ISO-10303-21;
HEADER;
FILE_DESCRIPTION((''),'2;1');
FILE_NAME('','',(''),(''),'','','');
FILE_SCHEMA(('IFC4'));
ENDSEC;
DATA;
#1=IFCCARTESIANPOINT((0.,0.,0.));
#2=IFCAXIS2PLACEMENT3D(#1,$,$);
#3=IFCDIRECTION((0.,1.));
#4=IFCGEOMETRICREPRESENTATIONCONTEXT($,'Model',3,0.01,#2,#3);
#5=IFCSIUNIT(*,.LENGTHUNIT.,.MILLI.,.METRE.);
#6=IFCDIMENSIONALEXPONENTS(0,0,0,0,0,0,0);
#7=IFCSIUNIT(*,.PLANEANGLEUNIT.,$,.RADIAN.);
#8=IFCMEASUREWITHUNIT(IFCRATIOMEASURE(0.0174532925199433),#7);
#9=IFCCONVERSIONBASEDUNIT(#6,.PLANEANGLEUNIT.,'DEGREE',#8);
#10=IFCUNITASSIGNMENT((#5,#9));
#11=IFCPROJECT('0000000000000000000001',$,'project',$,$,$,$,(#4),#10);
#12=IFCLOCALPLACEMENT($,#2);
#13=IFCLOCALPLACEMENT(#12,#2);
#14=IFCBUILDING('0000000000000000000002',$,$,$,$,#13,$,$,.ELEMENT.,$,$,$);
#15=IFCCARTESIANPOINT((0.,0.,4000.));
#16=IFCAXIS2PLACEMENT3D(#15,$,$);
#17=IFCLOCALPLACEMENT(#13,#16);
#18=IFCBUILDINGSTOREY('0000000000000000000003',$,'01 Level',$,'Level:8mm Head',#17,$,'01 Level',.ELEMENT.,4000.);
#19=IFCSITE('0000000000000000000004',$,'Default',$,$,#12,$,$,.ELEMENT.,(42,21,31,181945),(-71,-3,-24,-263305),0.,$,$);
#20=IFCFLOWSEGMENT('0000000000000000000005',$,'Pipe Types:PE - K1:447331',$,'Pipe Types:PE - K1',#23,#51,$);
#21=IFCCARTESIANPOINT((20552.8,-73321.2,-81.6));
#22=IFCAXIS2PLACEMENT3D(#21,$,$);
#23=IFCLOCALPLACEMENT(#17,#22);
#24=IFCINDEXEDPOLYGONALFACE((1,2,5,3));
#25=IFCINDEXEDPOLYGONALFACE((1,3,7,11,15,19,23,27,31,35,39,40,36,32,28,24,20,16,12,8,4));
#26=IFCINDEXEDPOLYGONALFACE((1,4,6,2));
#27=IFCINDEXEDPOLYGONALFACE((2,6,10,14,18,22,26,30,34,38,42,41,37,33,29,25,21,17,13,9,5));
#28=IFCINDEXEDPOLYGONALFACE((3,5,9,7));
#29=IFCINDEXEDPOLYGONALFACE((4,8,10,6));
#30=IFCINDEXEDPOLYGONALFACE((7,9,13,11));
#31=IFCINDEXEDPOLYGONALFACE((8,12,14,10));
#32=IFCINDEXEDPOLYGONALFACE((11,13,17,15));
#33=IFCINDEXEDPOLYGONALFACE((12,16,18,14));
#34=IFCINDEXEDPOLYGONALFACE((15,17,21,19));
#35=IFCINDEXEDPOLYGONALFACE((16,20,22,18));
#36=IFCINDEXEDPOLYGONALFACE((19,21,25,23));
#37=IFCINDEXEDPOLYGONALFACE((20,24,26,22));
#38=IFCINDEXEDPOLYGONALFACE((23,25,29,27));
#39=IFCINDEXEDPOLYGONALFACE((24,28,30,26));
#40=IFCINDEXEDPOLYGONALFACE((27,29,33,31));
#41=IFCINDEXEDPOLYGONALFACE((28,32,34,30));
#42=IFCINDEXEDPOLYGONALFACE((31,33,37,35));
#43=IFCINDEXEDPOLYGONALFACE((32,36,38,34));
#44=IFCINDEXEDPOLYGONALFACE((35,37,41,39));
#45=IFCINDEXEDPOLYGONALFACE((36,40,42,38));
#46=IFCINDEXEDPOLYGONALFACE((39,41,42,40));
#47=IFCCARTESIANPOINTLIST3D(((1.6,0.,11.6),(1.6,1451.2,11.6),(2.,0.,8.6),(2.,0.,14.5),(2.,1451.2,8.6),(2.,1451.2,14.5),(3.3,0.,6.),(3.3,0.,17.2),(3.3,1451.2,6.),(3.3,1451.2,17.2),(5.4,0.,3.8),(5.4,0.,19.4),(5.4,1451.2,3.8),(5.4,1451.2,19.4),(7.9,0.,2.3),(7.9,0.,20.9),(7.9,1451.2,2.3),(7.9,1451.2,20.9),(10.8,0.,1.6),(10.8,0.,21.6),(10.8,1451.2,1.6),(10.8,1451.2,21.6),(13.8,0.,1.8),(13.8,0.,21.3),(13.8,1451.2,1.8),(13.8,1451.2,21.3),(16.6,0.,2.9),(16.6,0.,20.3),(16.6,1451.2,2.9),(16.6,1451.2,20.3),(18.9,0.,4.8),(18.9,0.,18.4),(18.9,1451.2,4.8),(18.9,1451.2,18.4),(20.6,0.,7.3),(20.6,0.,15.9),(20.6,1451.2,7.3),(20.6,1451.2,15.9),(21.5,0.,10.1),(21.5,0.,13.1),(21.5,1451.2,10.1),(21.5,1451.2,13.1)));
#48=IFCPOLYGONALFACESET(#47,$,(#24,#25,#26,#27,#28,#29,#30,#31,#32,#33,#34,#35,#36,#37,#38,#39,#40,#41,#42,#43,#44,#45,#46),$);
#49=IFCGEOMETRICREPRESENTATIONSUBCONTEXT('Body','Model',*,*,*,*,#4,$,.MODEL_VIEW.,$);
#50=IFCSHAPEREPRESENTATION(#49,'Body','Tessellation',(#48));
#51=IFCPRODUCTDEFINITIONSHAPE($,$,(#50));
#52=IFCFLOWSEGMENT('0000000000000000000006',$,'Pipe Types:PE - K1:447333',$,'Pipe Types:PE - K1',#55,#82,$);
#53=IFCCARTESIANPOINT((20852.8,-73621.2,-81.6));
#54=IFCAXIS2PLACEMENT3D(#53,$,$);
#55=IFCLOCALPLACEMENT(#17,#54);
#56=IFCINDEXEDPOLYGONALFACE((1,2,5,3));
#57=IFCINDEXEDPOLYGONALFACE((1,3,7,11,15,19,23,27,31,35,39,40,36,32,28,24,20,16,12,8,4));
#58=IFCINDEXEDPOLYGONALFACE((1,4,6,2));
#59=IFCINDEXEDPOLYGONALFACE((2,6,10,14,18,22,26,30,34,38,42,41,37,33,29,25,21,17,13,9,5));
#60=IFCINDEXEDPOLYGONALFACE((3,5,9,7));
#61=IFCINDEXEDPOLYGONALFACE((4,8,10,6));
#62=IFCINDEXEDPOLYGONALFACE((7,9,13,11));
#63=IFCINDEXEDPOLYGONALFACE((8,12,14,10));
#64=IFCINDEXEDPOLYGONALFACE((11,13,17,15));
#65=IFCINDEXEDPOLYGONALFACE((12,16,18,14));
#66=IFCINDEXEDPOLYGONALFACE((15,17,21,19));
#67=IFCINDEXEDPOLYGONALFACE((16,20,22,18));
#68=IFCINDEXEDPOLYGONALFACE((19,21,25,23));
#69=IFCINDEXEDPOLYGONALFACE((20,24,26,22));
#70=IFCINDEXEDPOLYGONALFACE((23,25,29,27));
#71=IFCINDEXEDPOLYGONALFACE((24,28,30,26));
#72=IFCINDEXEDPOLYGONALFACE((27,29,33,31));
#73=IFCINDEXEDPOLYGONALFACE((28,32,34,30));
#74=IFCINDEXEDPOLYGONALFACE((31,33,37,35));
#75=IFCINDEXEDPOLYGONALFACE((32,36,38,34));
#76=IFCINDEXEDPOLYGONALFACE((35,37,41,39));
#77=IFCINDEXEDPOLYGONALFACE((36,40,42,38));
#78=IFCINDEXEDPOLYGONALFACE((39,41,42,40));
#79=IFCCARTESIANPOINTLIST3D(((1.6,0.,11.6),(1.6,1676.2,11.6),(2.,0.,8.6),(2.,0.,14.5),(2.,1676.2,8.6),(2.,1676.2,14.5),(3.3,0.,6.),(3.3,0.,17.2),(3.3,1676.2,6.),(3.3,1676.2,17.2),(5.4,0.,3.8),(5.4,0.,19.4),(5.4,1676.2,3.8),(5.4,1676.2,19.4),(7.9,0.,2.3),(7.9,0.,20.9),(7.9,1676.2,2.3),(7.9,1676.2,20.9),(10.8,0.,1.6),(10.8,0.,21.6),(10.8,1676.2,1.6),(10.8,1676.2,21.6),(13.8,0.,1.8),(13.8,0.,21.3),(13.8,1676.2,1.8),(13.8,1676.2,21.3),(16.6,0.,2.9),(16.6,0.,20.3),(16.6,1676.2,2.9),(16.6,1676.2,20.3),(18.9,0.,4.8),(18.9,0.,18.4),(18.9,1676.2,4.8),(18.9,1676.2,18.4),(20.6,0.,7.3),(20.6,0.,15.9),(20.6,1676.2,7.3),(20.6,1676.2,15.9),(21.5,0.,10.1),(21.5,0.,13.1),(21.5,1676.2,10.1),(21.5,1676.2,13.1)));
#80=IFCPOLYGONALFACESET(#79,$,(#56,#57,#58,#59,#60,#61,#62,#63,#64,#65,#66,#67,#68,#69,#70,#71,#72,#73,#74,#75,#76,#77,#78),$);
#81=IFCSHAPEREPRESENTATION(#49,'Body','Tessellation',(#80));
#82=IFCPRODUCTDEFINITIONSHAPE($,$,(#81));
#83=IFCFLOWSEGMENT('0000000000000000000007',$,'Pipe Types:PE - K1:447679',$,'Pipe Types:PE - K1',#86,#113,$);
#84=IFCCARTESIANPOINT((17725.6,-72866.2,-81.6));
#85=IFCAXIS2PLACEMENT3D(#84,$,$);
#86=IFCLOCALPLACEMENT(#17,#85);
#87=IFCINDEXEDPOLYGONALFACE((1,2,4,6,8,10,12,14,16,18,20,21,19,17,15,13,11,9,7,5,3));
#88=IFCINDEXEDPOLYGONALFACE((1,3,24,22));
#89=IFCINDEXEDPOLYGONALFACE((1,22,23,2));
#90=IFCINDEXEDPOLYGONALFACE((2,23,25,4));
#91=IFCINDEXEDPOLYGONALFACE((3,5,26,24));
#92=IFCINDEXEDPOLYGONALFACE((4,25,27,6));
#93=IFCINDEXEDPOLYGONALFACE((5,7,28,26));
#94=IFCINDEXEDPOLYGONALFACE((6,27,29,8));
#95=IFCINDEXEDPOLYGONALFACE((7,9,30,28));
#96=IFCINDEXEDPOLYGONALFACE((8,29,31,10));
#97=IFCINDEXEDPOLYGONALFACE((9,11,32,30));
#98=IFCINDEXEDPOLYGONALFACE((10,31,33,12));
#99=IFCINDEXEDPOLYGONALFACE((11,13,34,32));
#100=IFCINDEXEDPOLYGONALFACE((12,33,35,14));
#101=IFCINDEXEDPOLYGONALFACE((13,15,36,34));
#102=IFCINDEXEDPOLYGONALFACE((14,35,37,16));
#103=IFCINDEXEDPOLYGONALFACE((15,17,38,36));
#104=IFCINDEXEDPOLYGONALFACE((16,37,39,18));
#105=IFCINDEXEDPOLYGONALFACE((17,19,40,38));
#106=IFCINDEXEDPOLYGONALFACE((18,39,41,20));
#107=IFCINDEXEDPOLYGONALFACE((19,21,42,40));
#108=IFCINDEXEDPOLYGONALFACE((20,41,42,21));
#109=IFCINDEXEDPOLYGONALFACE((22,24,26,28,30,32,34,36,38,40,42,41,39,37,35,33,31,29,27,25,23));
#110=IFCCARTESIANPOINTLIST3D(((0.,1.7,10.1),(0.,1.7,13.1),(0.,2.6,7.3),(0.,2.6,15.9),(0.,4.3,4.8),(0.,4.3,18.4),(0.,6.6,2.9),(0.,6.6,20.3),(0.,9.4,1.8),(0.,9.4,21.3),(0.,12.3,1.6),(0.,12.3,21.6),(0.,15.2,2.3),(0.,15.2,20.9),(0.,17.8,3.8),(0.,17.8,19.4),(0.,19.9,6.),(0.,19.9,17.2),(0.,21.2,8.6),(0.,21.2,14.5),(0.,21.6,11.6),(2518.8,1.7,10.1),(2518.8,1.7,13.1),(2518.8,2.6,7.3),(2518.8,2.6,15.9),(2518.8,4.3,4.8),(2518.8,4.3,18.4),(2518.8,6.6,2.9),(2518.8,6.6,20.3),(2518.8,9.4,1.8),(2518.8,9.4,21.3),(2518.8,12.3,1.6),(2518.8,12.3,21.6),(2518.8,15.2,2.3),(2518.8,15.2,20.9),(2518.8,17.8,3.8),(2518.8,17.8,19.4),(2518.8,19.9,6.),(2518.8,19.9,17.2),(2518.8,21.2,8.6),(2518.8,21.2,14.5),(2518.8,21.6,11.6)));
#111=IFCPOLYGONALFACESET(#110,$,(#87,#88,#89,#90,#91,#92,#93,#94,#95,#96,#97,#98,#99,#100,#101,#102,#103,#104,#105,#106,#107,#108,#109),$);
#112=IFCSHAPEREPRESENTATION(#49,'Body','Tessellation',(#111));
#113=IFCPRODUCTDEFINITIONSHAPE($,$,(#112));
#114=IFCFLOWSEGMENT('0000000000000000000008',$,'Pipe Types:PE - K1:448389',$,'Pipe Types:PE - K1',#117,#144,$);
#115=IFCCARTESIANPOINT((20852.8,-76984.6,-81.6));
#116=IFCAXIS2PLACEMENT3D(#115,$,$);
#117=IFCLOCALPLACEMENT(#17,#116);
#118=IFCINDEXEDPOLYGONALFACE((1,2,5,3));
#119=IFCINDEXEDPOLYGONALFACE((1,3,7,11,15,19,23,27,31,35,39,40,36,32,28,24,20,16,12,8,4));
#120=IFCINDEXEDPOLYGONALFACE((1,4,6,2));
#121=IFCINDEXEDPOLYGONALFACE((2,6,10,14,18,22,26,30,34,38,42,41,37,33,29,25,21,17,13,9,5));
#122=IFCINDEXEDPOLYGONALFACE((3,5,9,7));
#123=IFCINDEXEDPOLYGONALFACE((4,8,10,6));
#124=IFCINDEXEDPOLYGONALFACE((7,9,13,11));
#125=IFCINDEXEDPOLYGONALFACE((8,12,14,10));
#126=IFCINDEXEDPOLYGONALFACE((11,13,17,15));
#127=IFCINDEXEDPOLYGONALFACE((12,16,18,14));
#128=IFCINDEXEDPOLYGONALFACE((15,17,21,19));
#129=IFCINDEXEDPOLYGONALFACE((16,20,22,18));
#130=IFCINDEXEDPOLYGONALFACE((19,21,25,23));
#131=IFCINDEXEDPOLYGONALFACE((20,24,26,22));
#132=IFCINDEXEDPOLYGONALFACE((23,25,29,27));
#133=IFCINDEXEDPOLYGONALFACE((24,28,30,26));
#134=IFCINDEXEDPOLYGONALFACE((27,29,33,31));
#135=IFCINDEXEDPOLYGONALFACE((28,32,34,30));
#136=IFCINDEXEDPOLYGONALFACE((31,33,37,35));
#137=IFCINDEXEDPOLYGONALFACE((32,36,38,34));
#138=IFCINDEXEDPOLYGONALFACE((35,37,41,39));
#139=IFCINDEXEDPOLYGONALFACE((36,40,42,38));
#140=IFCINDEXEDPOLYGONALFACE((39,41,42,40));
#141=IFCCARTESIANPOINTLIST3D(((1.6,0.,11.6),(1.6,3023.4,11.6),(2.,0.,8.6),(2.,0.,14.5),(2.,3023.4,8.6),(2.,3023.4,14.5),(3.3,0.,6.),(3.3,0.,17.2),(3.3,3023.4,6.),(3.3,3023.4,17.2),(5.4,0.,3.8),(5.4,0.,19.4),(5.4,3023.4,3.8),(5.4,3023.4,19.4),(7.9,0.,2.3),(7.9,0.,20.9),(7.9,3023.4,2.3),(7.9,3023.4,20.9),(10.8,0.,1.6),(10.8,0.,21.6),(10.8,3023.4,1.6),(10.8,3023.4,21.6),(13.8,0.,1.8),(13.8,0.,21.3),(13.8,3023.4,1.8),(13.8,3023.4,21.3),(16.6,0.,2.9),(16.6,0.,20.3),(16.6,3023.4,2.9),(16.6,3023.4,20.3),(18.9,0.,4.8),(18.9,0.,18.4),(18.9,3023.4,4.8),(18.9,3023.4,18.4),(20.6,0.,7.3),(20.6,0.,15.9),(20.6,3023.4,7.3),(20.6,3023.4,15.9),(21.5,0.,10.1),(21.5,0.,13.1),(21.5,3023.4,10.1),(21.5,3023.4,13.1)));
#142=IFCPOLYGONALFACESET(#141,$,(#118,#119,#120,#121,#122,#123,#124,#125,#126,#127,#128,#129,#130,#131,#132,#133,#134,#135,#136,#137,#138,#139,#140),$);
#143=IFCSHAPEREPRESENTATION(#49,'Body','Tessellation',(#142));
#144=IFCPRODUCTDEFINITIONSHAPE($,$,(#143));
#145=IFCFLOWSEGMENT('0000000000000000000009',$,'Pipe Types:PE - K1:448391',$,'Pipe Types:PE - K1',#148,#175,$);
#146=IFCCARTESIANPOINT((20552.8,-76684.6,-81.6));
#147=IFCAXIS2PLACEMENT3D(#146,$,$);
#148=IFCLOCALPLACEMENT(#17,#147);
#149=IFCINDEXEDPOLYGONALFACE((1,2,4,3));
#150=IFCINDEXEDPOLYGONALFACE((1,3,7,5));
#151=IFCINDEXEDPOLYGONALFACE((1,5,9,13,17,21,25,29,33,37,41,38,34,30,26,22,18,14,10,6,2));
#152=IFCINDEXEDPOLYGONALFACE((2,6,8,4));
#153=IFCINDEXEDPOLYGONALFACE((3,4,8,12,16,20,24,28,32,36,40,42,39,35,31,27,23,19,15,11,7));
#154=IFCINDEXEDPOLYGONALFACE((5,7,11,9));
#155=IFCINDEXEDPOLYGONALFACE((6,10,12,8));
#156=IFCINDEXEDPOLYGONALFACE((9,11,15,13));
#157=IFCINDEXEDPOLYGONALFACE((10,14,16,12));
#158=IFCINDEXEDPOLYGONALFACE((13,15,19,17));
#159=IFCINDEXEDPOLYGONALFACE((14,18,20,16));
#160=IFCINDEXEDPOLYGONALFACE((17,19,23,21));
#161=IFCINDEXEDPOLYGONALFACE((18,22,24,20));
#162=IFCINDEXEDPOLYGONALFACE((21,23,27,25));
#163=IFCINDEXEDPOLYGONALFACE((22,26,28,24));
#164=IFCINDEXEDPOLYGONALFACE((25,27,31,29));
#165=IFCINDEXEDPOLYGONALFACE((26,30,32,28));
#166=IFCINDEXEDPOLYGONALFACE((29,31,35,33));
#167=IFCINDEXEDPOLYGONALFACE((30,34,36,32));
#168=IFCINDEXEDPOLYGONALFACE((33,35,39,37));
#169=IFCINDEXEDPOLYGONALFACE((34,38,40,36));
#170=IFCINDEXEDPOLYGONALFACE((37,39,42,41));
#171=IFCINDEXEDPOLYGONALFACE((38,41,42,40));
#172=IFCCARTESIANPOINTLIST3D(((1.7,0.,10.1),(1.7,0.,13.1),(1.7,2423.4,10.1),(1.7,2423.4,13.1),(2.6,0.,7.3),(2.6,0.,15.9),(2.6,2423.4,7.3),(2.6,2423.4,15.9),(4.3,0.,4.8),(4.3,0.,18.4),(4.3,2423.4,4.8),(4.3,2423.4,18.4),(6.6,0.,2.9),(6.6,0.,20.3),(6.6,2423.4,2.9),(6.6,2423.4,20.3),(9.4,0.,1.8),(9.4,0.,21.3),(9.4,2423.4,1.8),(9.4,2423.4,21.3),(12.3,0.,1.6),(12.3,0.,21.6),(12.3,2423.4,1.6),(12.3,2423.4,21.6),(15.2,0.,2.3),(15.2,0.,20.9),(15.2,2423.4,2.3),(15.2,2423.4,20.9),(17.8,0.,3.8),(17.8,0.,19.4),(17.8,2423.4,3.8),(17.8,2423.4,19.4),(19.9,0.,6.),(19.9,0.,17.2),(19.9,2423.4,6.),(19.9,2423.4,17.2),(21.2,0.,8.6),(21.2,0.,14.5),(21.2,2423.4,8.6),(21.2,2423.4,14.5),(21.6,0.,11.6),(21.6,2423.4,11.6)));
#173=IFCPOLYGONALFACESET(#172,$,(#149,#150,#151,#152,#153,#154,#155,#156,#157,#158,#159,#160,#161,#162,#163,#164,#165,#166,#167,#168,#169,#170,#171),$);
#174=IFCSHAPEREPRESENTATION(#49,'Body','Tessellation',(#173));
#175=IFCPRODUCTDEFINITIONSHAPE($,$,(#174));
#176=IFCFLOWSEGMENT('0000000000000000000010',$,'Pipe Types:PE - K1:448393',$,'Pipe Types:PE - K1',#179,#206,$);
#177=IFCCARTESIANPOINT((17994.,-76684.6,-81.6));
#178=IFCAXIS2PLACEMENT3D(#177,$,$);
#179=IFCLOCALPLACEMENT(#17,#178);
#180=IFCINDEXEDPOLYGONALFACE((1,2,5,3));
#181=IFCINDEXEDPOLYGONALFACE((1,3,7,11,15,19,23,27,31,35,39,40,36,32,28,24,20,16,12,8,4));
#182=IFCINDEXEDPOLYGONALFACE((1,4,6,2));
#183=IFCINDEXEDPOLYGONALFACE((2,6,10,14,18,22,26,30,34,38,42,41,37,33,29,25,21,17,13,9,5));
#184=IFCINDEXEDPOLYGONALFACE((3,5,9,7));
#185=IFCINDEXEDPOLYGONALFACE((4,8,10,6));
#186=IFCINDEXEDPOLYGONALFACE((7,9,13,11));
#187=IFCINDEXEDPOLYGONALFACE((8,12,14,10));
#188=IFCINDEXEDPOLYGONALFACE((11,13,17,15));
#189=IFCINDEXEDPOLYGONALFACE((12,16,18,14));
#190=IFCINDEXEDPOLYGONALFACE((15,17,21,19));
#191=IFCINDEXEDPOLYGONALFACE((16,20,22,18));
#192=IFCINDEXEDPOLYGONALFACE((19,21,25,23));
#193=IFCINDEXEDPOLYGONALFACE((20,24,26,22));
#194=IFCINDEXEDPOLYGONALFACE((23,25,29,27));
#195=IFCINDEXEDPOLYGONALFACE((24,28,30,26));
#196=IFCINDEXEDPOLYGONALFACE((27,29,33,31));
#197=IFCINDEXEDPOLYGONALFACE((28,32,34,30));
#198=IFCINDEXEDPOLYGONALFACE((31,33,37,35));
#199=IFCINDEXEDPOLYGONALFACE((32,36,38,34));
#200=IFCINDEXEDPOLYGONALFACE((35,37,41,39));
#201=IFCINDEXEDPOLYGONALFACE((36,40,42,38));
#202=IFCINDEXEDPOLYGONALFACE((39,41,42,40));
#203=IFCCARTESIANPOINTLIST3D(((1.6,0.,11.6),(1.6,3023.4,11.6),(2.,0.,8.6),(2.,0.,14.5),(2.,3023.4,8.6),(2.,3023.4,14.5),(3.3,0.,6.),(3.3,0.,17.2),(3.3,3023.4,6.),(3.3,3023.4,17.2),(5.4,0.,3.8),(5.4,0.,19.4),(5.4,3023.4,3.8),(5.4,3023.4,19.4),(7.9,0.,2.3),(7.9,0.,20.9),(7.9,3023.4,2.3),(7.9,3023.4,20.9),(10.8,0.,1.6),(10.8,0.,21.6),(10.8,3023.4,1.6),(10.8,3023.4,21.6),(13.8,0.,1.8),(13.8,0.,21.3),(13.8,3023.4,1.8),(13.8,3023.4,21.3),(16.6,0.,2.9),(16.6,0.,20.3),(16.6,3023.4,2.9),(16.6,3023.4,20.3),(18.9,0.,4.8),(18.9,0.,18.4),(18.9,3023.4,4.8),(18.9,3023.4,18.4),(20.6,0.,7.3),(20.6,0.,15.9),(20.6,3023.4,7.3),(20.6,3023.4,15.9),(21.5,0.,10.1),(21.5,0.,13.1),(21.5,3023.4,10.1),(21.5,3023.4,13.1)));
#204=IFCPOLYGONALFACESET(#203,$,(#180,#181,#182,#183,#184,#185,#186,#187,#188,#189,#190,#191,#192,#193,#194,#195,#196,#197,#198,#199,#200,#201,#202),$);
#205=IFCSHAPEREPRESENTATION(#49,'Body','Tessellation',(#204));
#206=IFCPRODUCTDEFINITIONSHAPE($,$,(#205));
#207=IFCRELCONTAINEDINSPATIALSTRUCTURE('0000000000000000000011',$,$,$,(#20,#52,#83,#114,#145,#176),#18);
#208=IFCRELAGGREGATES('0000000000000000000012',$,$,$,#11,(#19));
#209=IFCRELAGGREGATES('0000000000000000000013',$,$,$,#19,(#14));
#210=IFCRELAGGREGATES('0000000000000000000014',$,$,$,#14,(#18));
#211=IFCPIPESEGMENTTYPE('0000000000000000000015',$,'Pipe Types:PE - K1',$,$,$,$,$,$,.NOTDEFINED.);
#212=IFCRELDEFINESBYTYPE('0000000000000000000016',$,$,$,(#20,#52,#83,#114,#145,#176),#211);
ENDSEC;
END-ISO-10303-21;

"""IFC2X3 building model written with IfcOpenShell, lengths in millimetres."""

from ifc_helpers import new_model, entity, si_unit, converted_unit, direction, frame, frame_2d, origin, origin_2d_with_axis, place, context, subcontext, project, spatial, circle, extrude, type_object, element, save


model = new_model("IFC2X3")

# Units and contexts
model_context = context("Model", 3, precision=0.01, world=origin(), true_north=direction((0.0, 1.0)))
body_context = subcontext(model_context, "Body", "Model", "MODEL_VIEW")
ifc_project = project(units=[si_unit("LENGTHUNIT", "METRE", prefix="MILLI"), converted_unit("PLANEANGLEUNIT", "DEGREE", entity("IfcRatioMeasure", 0.0174532925199433), si_unit("PLANEANGLEUNIT", "RADIAN"), dimensions=[0, 0, 0, 0, 0, 0, 0])], contexts=[model_context])

# Site, building, storey
site_placement = place(None, origin())
site = spatial("IfcSite", under=ifc_project, at=site_placement, Name="Default", CompositionType="ELEMENT", RefLatitude=(42, 21, 31, 181945), RefLongitude=(-71, -3, -24, -263305), RefElevation=0.0)
building_placement = place(site_placement, origin())
building = spatial("IfcBuilding", under=site, at=building_placement, CompositionType="ELEMENT")
storey_placement = place(building_placement, frame((0.0, 0.0, 4000.0)))
storey = spatial("IfcBuildingStorey", under=building, at=storey_placement, Name="01 Level", ObjectType="Level:8mm Head", LongName="01 Level", CompositionType="ELEMENT", Elevation=4000.0)

# Flow segments
pipe_segment_type = type_object("IfcPipeSegmentType", Name="Pipe Types:PE - K1", PredefinedType="NOTDEFINED")
flow_segment_1_placement = place(storey_placement, frame((20552.8, -73321.2, -81.6)))
element("IfcFlowSegment", 1, at=flow_segment_1_placement, inside=storey, type_object=pipe_segment_type, Name="Pipe Types:PE - K1:447331", ObjectType="Pipe Types:PE - K1", context=body_context, shape_type="SweptSolid", body=[
    extrude(circle(Radius=10.0, at=origin_2d_with_axis()), frame((11.6, 0.0, 11.6), z_axis=(0.0, 1.0, 0.0), x_axis=(-1.0, 0.0, 0.0)), (0.0, 0.0, 1.0), 1451.2),
])
flow_segment_2_placement = place(storey_placement, frame((20852.8, -73621.2, -81.6)))
element("IfcFlowSegment", 2, at=flow_segment_2_placement, inside=storey, type_object=pipe_segment_type, Name="Pipe Types:PE - K1:447333", ObjectType="Pipe Types:PE - K1", context=body_context, shape_type="SweptSolid", body=[
    extrude(circle(Radius=10.0, at=origin_2d_with_axis()), frame((11.6, 0.0, 11.6), z_axis=(0.0, 1.0, 0.0), x_axis=(-1.0, 0.0, 0.0)), (0.0, 0.0, 1.0), 1676.2),
])
flow_segment_3_placement = place(storey_placement, frame((17725.6, -72866.2, -81.6)))
element("IfcFlowSegment", 3, at=flow_segment_3_placement, inside=storey, type_object=pipe_segment_type, Name="Pipe Types:PE - K1:447679", ObjectType="Pipe Types:PE - K1", context=body_context, shape_type="SweptSolid", body=[
    extrude(circle(Radius=10.0, at=frame_2d((0.0, 0.0), x_axis=(1.0, 0.0))), frame((0.0, 11.6, 11.6), z_axis=(1.0, 0.0, 0.0), x_axis=(0.0, 1.0, 0.0)), (0.0, 0.0, 1.0), 2518.8),
])
flow_segment_4_placement = place(storey_placement, frame((20852.8, -76984.6, -81.6)))
element("IfcFlowSegment", 4, at=flow_segment_4_placement, inside=storey, type_object=pipe_segment_type, Name="Pipe Types:PE - K1:448389", ObjectType="Pipe Types:PE - K1", context=body_context, shape_type="SweptSolid", body=[
    extrude(circle(Radius=10.0, at=frame_2d((0.0, 0.0), x_axis=(1.0, 0.0))), frame((11.6, 0.0, 11.6), z_axis=(0.0, 1.0, 0.0), x_axis=(-1.0, 0.0, 0.0)), (0.0, 0.0, 1.0), 3023.4),
])
flow_segment_5_placement = place(storey_placement, frame((20552.8, -76684.6, -81.6)))
element("IfcFlowSegment", 5, at=flow_segment_5_placement, inside=storey, type_object=pipe_segment_type, Name="Pipe Types:PE - K1:448391", ObjectType="Pipe Types:PE - K1", context=body_context, shape_type="SweptSolid", body=[
    extrude(circle(Radius=10.0, at=origin_2d_with_axis()), frame((11.6, 0.0, 11.6), z_axis=(0.0, 1.0, 0.0), x_axis=(1.0, 0.0, 0.0)), (0.0, 0.0, 1.0), 2423.4),
])
flow_segment_6_placement = place(storey_placement, frame((17994.0, -76684.6, -81.6)))
element("IfcFlowSegment", 6, at=flow_segment_6_placement, inside=storey, type_object=pipe_segment_type, Name="Pipe Types:PE - K1:448393", ObjectType="Pipe Types:PE - K1", context=body_context, shape_type="SweptSolid", body=[
    extrude(circle(Radius=10.0, at=frame_2d((0.0, 0.0), x_axis=(1.0, 0.0))), frame((11.6, 0.0, 11.6), z_axis=(0.0, 1.0, 0.0), x_axis=(-1.0, 0.0, 0.0)), (0.0, 0.0, 1.0), 3023.4),
])

save(model, "model.ifc")
